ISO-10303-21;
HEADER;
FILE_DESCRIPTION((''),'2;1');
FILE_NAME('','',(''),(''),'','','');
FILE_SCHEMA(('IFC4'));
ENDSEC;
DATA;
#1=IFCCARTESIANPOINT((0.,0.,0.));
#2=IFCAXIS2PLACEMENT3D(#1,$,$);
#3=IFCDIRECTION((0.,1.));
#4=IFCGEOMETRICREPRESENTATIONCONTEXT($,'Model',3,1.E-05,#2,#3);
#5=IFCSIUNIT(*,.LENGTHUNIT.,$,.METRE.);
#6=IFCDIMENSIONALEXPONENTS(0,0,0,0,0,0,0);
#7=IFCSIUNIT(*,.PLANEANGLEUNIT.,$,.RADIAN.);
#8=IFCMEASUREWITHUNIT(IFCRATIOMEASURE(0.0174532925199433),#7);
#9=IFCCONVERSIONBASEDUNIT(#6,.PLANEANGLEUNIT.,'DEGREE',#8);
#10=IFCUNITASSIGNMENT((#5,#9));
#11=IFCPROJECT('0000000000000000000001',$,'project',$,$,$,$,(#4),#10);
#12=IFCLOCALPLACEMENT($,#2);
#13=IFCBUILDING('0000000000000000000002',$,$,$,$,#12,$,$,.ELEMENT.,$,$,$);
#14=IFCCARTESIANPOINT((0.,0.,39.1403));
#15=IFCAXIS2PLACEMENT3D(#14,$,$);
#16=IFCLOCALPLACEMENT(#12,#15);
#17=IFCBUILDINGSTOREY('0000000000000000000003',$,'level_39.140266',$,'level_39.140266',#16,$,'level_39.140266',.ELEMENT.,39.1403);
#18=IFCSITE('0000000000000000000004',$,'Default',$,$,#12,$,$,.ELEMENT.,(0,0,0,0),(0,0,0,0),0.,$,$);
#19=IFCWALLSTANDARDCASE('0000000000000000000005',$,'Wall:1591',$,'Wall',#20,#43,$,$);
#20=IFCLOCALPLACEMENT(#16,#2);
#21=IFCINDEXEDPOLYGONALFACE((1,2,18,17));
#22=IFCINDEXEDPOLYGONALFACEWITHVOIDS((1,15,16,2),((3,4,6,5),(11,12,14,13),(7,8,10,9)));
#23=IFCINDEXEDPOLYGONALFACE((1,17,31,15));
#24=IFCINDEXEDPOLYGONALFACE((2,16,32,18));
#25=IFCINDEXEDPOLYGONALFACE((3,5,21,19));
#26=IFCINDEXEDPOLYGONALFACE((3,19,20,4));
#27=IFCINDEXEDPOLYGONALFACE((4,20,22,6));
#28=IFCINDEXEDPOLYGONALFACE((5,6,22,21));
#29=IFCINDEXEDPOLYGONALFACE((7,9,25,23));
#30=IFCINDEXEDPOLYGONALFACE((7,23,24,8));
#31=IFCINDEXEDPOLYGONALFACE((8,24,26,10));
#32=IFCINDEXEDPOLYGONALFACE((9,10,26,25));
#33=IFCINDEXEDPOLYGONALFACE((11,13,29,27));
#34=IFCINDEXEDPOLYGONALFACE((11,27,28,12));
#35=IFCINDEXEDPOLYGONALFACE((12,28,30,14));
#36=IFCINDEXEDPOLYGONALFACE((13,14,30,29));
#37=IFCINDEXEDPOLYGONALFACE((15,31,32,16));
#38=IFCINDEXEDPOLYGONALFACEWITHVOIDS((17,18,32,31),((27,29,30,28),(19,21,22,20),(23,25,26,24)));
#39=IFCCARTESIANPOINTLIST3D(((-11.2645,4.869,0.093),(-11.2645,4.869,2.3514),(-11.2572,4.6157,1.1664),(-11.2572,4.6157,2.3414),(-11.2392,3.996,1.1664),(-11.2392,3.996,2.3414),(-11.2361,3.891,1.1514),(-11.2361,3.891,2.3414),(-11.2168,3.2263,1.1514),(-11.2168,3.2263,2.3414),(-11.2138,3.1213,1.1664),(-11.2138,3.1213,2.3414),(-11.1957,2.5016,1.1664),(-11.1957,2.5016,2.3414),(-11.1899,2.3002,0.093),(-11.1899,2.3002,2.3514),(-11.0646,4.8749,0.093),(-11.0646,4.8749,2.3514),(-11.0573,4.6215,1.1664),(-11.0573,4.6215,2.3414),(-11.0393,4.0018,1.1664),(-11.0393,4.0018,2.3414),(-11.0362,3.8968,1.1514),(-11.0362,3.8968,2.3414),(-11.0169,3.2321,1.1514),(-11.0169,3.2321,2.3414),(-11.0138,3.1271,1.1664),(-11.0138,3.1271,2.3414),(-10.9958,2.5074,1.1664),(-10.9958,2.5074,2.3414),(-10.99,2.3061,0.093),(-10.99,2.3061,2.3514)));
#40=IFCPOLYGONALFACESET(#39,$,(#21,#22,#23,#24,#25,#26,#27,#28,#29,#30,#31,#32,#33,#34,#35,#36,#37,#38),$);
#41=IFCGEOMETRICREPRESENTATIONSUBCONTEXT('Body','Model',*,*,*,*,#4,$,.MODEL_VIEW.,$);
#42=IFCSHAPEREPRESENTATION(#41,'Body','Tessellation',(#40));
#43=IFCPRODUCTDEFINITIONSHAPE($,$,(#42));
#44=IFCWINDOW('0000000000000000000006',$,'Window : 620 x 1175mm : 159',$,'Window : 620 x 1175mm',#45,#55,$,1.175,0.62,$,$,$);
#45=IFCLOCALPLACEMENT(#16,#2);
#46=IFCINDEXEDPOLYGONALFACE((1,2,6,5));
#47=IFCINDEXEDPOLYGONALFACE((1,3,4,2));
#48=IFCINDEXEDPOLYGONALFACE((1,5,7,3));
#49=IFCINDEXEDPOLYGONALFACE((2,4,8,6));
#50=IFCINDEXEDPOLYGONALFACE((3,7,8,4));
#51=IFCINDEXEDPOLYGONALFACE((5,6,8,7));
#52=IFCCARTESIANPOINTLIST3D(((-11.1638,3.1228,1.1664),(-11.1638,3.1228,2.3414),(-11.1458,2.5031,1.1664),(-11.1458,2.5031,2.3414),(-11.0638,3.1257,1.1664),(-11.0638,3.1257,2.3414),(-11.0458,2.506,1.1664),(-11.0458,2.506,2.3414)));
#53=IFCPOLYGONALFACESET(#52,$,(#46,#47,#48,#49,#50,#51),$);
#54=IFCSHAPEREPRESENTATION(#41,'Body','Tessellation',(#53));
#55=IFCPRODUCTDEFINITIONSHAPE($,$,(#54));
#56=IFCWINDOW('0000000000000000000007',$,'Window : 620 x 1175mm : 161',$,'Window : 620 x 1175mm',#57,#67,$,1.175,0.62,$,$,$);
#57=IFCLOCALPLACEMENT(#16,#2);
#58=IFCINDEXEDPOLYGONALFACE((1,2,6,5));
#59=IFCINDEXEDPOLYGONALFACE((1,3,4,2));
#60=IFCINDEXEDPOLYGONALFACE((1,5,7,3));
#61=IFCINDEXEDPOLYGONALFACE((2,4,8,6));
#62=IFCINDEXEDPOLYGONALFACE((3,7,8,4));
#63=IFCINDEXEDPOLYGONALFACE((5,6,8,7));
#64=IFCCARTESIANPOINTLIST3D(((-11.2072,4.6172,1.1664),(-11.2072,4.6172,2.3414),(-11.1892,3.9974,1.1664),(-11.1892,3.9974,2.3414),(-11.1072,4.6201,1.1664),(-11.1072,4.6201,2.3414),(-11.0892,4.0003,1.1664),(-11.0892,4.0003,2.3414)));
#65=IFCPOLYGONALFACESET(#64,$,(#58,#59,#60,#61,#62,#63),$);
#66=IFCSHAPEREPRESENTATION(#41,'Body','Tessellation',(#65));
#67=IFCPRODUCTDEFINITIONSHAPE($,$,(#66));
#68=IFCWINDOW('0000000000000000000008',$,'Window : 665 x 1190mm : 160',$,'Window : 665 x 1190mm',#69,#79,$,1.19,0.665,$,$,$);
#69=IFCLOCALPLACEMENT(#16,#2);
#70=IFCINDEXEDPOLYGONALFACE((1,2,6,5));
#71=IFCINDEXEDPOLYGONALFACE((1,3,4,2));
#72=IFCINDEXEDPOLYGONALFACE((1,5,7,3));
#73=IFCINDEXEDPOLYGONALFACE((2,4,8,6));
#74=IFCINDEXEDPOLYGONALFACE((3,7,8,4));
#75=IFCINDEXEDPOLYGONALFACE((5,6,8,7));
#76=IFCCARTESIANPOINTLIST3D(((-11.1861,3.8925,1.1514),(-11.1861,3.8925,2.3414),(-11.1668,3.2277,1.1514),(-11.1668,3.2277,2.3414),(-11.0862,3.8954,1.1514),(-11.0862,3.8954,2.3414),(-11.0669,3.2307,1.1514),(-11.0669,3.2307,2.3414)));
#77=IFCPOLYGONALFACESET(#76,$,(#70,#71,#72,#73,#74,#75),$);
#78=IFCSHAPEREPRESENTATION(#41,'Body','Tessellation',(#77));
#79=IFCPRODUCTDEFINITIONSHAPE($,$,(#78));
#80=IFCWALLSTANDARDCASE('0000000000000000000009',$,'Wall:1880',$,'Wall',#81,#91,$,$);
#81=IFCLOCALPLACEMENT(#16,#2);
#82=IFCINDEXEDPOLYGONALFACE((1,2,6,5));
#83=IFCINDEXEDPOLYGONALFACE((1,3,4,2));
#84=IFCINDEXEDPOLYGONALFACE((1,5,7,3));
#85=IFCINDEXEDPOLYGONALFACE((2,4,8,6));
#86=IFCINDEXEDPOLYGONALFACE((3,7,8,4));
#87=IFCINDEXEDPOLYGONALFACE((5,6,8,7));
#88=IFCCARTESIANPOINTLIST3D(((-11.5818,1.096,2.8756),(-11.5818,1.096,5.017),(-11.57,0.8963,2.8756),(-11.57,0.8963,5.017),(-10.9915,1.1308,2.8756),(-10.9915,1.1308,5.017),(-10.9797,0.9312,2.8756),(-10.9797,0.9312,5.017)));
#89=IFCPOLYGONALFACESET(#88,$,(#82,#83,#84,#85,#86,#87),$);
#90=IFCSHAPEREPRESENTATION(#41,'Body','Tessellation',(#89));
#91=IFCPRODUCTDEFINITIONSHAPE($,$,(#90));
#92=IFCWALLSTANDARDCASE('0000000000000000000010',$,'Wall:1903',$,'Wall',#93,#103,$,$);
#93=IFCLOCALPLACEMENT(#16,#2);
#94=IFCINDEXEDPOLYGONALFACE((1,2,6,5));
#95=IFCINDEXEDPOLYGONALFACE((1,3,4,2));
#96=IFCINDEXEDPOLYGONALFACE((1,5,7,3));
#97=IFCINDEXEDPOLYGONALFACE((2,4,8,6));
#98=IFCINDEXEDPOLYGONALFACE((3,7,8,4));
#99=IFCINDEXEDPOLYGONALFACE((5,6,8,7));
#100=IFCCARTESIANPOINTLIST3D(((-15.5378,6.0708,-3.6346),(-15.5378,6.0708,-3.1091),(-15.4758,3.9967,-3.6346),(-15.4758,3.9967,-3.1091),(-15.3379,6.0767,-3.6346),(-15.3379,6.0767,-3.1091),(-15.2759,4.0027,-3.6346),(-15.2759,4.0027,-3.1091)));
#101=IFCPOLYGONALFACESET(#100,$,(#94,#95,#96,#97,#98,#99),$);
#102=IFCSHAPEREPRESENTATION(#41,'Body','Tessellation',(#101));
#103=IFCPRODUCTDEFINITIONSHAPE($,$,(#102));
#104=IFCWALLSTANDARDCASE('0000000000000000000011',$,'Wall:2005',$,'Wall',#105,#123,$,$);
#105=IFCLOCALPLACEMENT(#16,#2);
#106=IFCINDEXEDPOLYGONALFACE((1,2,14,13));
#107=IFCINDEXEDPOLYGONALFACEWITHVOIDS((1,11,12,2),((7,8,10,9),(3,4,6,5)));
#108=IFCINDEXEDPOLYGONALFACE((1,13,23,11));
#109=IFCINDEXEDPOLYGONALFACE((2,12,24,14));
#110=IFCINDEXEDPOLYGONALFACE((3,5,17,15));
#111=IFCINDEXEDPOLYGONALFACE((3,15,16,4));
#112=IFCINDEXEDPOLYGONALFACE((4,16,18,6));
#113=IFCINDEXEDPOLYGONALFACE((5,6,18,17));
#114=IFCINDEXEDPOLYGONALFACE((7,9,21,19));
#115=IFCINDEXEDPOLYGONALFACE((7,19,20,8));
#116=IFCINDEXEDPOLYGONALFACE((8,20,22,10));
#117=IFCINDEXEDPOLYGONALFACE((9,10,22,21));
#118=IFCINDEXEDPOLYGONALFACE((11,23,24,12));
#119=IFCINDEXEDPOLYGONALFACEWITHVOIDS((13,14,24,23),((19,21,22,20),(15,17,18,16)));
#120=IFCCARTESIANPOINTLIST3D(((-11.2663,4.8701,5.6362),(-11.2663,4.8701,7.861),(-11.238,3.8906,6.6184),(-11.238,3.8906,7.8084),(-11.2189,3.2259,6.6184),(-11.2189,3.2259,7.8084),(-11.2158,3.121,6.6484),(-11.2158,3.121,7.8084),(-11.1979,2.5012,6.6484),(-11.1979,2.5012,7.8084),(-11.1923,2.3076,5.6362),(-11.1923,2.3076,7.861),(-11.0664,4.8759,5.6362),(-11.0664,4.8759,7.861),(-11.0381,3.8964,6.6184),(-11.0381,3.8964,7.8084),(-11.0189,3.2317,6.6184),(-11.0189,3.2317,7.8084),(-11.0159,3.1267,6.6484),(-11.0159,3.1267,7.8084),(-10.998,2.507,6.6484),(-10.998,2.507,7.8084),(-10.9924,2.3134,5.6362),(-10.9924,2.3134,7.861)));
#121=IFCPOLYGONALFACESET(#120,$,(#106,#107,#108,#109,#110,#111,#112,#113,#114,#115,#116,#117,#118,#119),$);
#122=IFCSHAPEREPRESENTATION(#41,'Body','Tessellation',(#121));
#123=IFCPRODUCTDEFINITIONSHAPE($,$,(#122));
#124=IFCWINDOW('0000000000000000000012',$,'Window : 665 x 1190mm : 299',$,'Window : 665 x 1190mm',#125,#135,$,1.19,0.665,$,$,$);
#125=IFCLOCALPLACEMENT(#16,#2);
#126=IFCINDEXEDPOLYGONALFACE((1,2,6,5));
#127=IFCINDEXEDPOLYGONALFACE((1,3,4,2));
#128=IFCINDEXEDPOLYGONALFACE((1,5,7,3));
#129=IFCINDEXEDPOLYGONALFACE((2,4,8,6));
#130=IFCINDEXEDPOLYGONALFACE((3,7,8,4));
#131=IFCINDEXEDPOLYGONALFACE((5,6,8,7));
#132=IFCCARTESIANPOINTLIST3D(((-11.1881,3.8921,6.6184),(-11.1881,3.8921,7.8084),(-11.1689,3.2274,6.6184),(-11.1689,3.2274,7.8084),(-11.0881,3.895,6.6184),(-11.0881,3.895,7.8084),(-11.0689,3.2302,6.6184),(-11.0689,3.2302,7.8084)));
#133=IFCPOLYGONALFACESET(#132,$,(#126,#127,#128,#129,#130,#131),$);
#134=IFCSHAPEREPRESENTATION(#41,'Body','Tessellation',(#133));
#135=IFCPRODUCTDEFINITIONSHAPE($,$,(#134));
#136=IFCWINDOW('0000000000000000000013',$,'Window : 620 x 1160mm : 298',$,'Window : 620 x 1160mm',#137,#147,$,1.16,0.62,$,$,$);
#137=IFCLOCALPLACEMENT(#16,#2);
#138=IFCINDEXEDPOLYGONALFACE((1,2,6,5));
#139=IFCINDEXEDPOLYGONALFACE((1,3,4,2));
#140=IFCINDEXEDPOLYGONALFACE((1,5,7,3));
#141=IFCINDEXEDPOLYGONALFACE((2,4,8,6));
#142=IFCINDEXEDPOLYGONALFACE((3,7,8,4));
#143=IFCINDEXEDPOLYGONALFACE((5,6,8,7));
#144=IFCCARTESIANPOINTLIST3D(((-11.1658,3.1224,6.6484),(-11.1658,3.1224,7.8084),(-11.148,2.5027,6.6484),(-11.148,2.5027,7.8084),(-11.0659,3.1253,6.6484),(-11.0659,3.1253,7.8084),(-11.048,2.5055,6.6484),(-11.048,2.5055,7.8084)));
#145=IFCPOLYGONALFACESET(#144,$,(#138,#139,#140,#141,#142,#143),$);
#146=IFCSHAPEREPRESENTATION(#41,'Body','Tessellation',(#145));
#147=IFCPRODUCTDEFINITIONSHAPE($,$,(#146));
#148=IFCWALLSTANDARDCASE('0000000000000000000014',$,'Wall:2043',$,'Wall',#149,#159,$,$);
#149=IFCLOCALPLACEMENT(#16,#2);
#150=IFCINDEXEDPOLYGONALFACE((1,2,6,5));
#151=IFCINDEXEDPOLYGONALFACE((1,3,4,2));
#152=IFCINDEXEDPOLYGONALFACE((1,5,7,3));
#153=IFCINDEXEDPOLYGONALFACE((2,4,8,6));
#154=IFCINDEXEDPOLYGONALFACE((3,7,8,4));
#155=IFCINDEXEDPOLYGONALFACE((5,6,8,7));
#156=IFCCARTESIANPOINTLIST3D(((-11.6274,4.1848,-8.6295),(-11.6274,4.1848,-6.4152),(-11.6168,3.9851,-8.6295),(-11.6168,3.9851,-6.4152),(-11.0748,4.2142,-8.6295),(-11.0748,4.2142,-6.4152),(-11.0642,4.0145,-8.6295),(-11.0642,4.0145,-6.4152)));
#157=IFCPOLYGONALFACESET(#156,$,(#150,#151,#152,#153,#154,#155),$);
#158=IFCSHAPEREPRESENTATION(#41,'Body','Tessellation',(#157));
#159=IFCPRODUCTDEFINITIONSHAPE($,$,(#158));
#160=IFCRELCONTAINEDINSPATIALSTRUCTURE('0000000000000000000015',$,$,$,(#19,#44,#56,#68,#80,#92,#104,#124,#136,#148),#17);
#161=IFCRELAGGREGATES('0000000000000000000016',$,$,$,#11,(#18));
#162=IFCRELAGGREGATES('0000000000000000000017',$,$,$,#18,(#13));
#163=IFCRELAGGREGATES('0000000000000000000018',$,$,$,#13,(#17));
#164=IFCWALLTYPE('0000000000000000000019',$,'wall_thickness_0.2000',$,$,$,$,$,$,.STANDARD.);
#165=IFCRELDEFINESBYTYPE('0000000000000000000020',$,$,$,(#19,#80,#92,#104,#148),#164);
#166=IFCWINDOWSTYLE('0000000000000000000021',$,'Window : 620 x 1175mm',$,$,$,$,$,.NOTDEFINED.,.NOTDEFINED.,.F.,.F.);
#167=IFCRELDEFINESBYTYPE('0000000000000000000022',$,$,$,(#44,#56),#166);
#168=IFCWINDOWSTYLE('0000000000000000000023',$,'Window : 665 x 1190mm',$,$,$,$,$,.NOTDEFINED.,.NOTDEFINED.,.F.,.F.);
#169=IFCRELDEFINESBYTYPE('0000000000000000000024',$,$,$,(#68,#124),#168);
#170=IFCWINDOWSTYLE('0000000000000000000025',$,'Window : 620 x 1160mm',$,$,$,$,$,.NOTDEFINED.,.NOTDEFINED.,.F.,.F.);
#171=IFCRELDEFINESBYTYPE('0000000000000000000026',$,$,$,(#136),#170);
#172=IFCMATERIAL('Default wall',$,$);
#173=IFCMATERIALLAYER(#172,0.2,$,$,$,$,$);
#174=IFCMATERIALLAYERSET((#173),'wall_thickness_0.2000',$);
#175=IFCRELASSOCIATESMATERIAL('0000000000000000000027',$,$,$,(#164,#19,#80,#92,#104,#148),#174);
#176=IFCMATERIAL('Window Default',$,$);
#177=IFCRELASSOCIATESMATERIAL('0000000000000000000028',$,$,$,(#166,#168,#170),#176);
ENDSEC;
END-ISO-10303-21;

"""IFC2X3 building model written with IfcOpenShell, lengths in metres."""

from ifc_helpers import new_model, entity, si_unit, converted_unit, direction, frame, frame_2d, origin, origin_2d_with_axis, place, context, subcontext, project, spatial, polyline, rectangle, outline, extrude, source, transform, mapped, material, layer, layer_set, layer_usage, type_object, type_shapes, element, fill, save


model = new_model("IFC2X3")

# Units and contexts
model_context = context("Model", 3, precision=1e-05, world=origin(), true_north=direction((0.0, 1.0)))
body_context = subcontext(model_context, "Body", "Model", "MODEL_VIEW")
ifc_project = project(units=[si_unit("LENGTHUNIT", "METRE"), converted_unit("PLANEANGLEUNIT", "DEGREE", entity("IfcRatioMeasure", 0.0174532925199433), si_unit("PLANEANGLEUNIT", "RADIAN"), dimensions=[0, 0, 0, 0, 0, 0, 0])], contexts=[model_context])

# Site, building, storey
placement_1 = place(None, origin())
site = spatial("IfcSite", under=ifc_project, at=placement_1, Name="Default", CompositionType="ELEMENT", RefLatitude=(0, 0, 0, 0), RefLongitude=(0, 0, 0, 0), RefElevation=0.0)
building = spatial("IfcBuilding", under=site, at=placement_1, CompositionType="ELEMENT")
storey_placement = place(placement_1, frame((0.0, 0.0, 39.1403)))
storey = spatial("IfcBuildingStorey", under=building, at=storey_placement, Name="level_39.140266", ObjectType="level_39.140266", LongName="level_39.140266", CompositionType="ELEMENT", Elevation=39.1403)

# Shared definitions
ifc_material_1 = material(Name="Default wall")
ifc_layer = layer(ifc_material_1, 0.2)
ifc_layer_set = layer_set([ifc_layer], Name="wall_thickness_0.2000")
ifc_layer_usage = layer_usage(ifc_layer_set, "AXIS2", "POSITIVE", -0.1)
wall_type = type_object("IfcWallType", Name="wall_thickness_0.2000", PredefinedType="STANDARD", material=ifc_layer_set)
ifc_material_2 = material(Name="Window Default")

# Wall, openings, windows
placement_2 = place(placement_1, frame((0.0, 0.0, 39.2333)))
wall_1_placement = place(placement_2, frame((-11.0899, 2.3032, 0.0), z_axis=(0.0, 0.0, 1.0), x_axis=(-0.029051, 0.999578, 0.0)))
wall_1 = element("IfcWallStandardCase", 1, at=wall_1_placement, inside=storey, type_object=wall_type, material=ifc_layer_usage, Name="Wall:1591", ObjectType="Wall", context=body_context, shape_type="SweptSolid", body=[
    extrude(outline(polyline([(2.5699, -0.1), (2.5699, 0.1), (0.0, 0.1), (0.0, -0.1), (2.5699, -0.1)])), origin(), (0.0, 0.0, 1.0), 2.2584),
])
opening_1_placement = place(wall_1_placement, frame((0.2014, -0.1, 1.0734)))
opening_1 = element("IfcOpeningElement", 2, at=opening_1_placement, cuts=wall_1, ObjectType="Opening", context=body_context, shape_type="SweptSolid", body=[
    extrude(rectangle(XDim=0.62, YDim=1.175, at=frame_2d((0.5875, 0.31), x_axis=(0.0, 1.0))), frame((0.0, 0.0, 0.0), z_axis=(0.0, 1.0, 0.0), x_axis=(0.0, 0.0, 1.0)), (0.0, 0.0, 1.0), 0.2),
])
opening_2_placement = place(wall_1_placement, frame((0.9264, -0.1, 1.0584)))
opening_2 = element("IfcOpeningElement", 3, at=opening_2_placement, cuts=wall_1, ObjectType="Opening", context=body_context, shape_type="SweptSolid", body=[
    extrude(rectangle(XDim=0.665, YDim=1.19, at=frame_2d((0.595, 0.3325), x_axis=(0.0, 1.0))), frame((0.0, 0.0, 0.0), z_axis=(0.0, 1.0, 0.0), x_axis=(0.0, 0.0, 1.0)), (0.0, 0.0, 1.0), 0.2),
])
opening_3_placement = place(wall_1_placement, frame((1.6964, -0.1, 1.0734)))
opening_3 = element("IfcOpeningElement", 4, at=opening_3_placement, cuts=wall_1, ObjectType="Opening", context=body_context, shape_type="SweptSolid", body=[
    extrude(rectangle(XDim=0.62, YDim=1.175, at=frame_2d((0.5875, 0.31), x_axis=(0.0, 1.0))), frame((0.0, 0.0, 0.0), z_axis=(0.0, 1.0, 0.0), x_axis=(0.0, 0.0, 1.0)), (0.0, 0.0, 1.0), 0.2),
])
window_style_1 = type_object("IfcWindowStyle", Name="Window : 620 x 1175mm", ConstructionType="NOTDEFINED", OperationType="NOTDEFINED", ParameterTakesPrecedence=False, Sizeable=False, material=ifc_material_2)
shared_shape_1 = source(origin(), body_context, "Body", "SweptSolid", [
    extrude(rectangle(XDim=0.1, YDim=0.62, at=origin_2d_with_axis()), frame((0.31, 0.1, 0.0), z_axis=(0.0, 0.0, 1.0), x_axis=(0.0, 1.0, 0.0)), (0.0, 0.0, 1.0), 1.175),
])
type_shapes(window_style_1, [shared_shape_1])
window_1_placement = place(opening_1_placement, origin())
window_1 = element("IfcWindow", 5, at=window_1_placement, inside=storey, type_object=window_style_1, Name="Window : 620 x 1175mm : 159", ObjectType="Window : 620 x 1175mm", OverallHeight=1.175, OverallWidth=0.62, context=body_context, shape_type="MappedRepresentation", body=[
    mapped(shared_shape_1, transform((0.0, 0.0, 0.0), scale=1.0)),
])
fill(opening_1, window_1)
window_2_placement = place(opening_3_placement, origin())
window_2 = element("IfcWindow", 6, at=window_2_placement, inside=storey, type_object=window_style_1, Name="Window : 620 x 1175mm : 161", ObjectType="Window : 620 x 1175mm", OverallHeight=1.175, OverallWidth=0.62, context=body_context, shape_type="MappedRepresentation", body=[
    mapped(shared_shape_1, transform((0.0, 0.0, 0.0), scale=1.0)),
])
fill(opening_3, window_2)
window_style_2 = type_object("IfcWindowStyle", Name="Window : 665 x 1190mm", ConstructionType="NOTDEFINED", OperationType="NOTDEFINED", ParameterTakesPrecedence=False, Sizeable=False, material=ifc_material_2)
shared_shape_2 = source(origin(), body_context, "Body", "SweptSolid", [
    extrude(rectangle(XDim=0.1, YDim=0.665, at=origin_2d_with_axis()), frame((0.3325, 0.1, 0.0), z_axis=(0.0, 0.0, 1.0), x_axis=(0.0, 1.0, 0.0)), (0.0, 0.0, 1.0), 1.19),
])
type_shapes(window_style_2, [shared_shape_2])
window_3_placement = place(opening_2_placement, origin())
window_3 = element("IfcWindow", 7, at=window_3_placement, inside=storey, type_object=window_style_2, Name="Window : 665 x 1190mm : 160", ObjectType="Window : 665 x 1190mm", OverallHeight=1.19, OverallWidth=0.665, context=body_context, shape_type="MappedRepresentation", body=[
    mapped(shared_shape_2, transform((0.0, 0.0, 0.0), scale=1.0)),
])
fill(opening_2, window_3)

# Walls
placement_3 = place(placement_1, frame((0.0, 0.0, 42.0159)))
wall_2_placement = place(placement_3, frame((-10.9856, 1.031, 0.0), z_axis=(0.0, 0.0, 1.0), x_axis=(-0.998263, -0.05892, 0.0)))
element("IfcWallStandardCase", 8, at=wall_2_placement, inside=storey, type_object=wall_type, material=ifc_layer_usage, Name="Wall:1880", ObjectType="Wall", context=body_context, shape_type="SweptSolid", body=[
    extrude(outline(polyline([(0.5913, -0.1), (0.5913, 0.1), (0.0, 0.1), (0.0, -0.1), (0.5913, -0.1)])), origin(), (0.0, 0.0, 1.0), 2.1414),
])
placement_4 = place(placement_1, frame((0.0, 0.0, 35.5057)))
wall_3_placement = place(placement_4, frame((-15.3758, 3.9997, 0.0), z_axis=(0.0, 0.0, 1.0), x_axis=(-0.02989, 0.999553, 0.0)))
element("IfcWallStandardCase", 9, at=wall_3_placement, inside=storey, type_object=wall_type, material=ifc_layer_usage, Name="Wall:1903", ObjectType="Wall", context=body_context, shape_type="SweptSolid", body=[
    extrude(outline(polyline([(2.075, -0.1), (2.075, 0.1), (0.0, 0.1), (0.0, -0.1), (2.075, -0.1)])), origin(), (0.0, 0.0, 1.0), 0.5255),
])

# Wall, openings, windows
placement_5 = place(placement_1, frame((0.0, 0.0, 44.7765)))
wall_4_placement = place(placement_5, frame((-11.0924, 2.3105, 0.0), z_axis=(0.0, 0.0, 1.0), x_axis=(-0.028854, 0.999584, 0.0)))
wall_4 = element("IfcWallStandardCase", 10, at=wall_4_placement, inside=storey, type_object=wall_type, material=ifc_layer_usage, Name="Wall:2005", ObjectType="Wall", context=body_context, shape_type="SweptSolid", body=[
    extrude(outline(polyline([(2.5635, -0.1), (2.5635, 0.1), (0.0, 0.1), (0.0, -0.1), (2.5635, -0.1)])), origin(), (0.0, 0.0, 1.0), 2.2248),
])
opening_4_placement = place(wall_4_placement, frame((0.1937, -0.1, 1.0122)))
opening_4 = element("IfcOpeningElement", 11, at=opening_4_placement, cuts=wall_4, ObjectType="Opening", context=body_context, shape_type="SweptSolid", body=[
    extrude(rectangle(XDim=0.62, YDim=1.16, at=frame_2d((0.58, 0.31), x_axis=(0.0, 1.0))), frame((0.0, 0.0, 0.0), z_axis=(0.0, 1.0, 0.0), x_axis=(0.0, 0.0, 1.0)), (0.0, 0.0, 1.0), 0.2),
])
opening_5_placement = place(wall_4_placement, frame((0.9187, -0.1, 0.9822)))
opening_5 = element("IfcOpeningElement", 12, at=opening_5_placement, cuts=wall_4, ObjectType="Opening", context=body_context, shape_type="SweptSolid", body=[
    extrude(rectangle(XDim=0.665, YDim=1.19, at=frame_2d((0.595, 0.3325), x_axis=(0.0, 1.0))), frame((0.0, 0.0, 0.0), z_axis=(0.0, 1.0, 0.0), x_axis=(0.0, 0.0, 1.0)), (0.0, 0.0, 1.0), 0.2),
])
window_4_placement = place(opening_5_placement, origin())
window_4 = element("IfcWindow", 13, at=window_4_placement, inside=storey, type_object=window_style_2, Name="Window : 665 x 1190mm : 299", ObjectType="Window : 665 x 1190mm", OverallHeight=1.19, OverallWidth=0.665, context=body_context, shape_type="MappedRepresentation", body=[
    mapped(shared_shape_2, transform((0.0, 0.0, 0.0), scale=1.0)),
])
fill(opening_5, window_4)
window_style_3 = type_object("IfcWindowStyle", Name="Window : 620 x 1160mm", ConstructionType="NOTDEFINED", OperationType="NOTDEFINED", ParameterTakesPrecedence=False, Sizeable=False, material=ifc_material_2)
shared_shape_3 = source(origin(), body_context, "Body", "SweptSolid", [
    extrude(rectangle(XDim=0.1, YDim=0.62, at=origin_2d_with_axis()), frame((0.31, 0.1, 0.0), z_axis=(0.0, 0.0, 1.0), x_axis=(0.0, 1.0, 0.0)), (0.0, 0.0, 1.0), 1.16),
])
type_shapes(window_style_3, [shared_shape_3])
window_5_placement = place(opening_4_placement, origin())
window_5 = element("IfcWindow", 14, at=window_5_placement, inside=storey, type_object=window_style_3, Name="Window : 620 x 1160mm : 298", ObjectType="Window : 620 x 1160mm", OverallHeight=1.16, OverallWidth=0.62, context=body_context, shape_type="MappedRepresentation", body=[
    mapped(shared_shape_3, transform((0.0, 0.0, 0.0), scale=1.0)),
])
fill(opening_4, window_5)

# Wall
placement_6 = place(placement_1, frame((0.0, 0.0, 30.5108)))
wall_5_placement = place(placement_6, frame((-11.0695, 4.1143, 0.0), z_axis=(0.0, 0.0, 1.0), x_axis=(-0.998585, -0.053174, 0.0)))
element("IfcWallStandardCase", 15, at=wall_5_placement, inside=storey, type_object=wall_type, material=ifc_layer_usage, Name="Wall:2043", ObjectType="Wall", context=body_context, shape_type="SweptSolid", body=[
    extrude(outline(polyline([(0.5534, -0.1), (0.5534, 0.1), (0.0, 0.1), (0.0, -0.1), (0.5534, -0.1)])), origin(), (0.0, 0.0, 1.0), 2.2143),
])

save(model, "model.ifc")
